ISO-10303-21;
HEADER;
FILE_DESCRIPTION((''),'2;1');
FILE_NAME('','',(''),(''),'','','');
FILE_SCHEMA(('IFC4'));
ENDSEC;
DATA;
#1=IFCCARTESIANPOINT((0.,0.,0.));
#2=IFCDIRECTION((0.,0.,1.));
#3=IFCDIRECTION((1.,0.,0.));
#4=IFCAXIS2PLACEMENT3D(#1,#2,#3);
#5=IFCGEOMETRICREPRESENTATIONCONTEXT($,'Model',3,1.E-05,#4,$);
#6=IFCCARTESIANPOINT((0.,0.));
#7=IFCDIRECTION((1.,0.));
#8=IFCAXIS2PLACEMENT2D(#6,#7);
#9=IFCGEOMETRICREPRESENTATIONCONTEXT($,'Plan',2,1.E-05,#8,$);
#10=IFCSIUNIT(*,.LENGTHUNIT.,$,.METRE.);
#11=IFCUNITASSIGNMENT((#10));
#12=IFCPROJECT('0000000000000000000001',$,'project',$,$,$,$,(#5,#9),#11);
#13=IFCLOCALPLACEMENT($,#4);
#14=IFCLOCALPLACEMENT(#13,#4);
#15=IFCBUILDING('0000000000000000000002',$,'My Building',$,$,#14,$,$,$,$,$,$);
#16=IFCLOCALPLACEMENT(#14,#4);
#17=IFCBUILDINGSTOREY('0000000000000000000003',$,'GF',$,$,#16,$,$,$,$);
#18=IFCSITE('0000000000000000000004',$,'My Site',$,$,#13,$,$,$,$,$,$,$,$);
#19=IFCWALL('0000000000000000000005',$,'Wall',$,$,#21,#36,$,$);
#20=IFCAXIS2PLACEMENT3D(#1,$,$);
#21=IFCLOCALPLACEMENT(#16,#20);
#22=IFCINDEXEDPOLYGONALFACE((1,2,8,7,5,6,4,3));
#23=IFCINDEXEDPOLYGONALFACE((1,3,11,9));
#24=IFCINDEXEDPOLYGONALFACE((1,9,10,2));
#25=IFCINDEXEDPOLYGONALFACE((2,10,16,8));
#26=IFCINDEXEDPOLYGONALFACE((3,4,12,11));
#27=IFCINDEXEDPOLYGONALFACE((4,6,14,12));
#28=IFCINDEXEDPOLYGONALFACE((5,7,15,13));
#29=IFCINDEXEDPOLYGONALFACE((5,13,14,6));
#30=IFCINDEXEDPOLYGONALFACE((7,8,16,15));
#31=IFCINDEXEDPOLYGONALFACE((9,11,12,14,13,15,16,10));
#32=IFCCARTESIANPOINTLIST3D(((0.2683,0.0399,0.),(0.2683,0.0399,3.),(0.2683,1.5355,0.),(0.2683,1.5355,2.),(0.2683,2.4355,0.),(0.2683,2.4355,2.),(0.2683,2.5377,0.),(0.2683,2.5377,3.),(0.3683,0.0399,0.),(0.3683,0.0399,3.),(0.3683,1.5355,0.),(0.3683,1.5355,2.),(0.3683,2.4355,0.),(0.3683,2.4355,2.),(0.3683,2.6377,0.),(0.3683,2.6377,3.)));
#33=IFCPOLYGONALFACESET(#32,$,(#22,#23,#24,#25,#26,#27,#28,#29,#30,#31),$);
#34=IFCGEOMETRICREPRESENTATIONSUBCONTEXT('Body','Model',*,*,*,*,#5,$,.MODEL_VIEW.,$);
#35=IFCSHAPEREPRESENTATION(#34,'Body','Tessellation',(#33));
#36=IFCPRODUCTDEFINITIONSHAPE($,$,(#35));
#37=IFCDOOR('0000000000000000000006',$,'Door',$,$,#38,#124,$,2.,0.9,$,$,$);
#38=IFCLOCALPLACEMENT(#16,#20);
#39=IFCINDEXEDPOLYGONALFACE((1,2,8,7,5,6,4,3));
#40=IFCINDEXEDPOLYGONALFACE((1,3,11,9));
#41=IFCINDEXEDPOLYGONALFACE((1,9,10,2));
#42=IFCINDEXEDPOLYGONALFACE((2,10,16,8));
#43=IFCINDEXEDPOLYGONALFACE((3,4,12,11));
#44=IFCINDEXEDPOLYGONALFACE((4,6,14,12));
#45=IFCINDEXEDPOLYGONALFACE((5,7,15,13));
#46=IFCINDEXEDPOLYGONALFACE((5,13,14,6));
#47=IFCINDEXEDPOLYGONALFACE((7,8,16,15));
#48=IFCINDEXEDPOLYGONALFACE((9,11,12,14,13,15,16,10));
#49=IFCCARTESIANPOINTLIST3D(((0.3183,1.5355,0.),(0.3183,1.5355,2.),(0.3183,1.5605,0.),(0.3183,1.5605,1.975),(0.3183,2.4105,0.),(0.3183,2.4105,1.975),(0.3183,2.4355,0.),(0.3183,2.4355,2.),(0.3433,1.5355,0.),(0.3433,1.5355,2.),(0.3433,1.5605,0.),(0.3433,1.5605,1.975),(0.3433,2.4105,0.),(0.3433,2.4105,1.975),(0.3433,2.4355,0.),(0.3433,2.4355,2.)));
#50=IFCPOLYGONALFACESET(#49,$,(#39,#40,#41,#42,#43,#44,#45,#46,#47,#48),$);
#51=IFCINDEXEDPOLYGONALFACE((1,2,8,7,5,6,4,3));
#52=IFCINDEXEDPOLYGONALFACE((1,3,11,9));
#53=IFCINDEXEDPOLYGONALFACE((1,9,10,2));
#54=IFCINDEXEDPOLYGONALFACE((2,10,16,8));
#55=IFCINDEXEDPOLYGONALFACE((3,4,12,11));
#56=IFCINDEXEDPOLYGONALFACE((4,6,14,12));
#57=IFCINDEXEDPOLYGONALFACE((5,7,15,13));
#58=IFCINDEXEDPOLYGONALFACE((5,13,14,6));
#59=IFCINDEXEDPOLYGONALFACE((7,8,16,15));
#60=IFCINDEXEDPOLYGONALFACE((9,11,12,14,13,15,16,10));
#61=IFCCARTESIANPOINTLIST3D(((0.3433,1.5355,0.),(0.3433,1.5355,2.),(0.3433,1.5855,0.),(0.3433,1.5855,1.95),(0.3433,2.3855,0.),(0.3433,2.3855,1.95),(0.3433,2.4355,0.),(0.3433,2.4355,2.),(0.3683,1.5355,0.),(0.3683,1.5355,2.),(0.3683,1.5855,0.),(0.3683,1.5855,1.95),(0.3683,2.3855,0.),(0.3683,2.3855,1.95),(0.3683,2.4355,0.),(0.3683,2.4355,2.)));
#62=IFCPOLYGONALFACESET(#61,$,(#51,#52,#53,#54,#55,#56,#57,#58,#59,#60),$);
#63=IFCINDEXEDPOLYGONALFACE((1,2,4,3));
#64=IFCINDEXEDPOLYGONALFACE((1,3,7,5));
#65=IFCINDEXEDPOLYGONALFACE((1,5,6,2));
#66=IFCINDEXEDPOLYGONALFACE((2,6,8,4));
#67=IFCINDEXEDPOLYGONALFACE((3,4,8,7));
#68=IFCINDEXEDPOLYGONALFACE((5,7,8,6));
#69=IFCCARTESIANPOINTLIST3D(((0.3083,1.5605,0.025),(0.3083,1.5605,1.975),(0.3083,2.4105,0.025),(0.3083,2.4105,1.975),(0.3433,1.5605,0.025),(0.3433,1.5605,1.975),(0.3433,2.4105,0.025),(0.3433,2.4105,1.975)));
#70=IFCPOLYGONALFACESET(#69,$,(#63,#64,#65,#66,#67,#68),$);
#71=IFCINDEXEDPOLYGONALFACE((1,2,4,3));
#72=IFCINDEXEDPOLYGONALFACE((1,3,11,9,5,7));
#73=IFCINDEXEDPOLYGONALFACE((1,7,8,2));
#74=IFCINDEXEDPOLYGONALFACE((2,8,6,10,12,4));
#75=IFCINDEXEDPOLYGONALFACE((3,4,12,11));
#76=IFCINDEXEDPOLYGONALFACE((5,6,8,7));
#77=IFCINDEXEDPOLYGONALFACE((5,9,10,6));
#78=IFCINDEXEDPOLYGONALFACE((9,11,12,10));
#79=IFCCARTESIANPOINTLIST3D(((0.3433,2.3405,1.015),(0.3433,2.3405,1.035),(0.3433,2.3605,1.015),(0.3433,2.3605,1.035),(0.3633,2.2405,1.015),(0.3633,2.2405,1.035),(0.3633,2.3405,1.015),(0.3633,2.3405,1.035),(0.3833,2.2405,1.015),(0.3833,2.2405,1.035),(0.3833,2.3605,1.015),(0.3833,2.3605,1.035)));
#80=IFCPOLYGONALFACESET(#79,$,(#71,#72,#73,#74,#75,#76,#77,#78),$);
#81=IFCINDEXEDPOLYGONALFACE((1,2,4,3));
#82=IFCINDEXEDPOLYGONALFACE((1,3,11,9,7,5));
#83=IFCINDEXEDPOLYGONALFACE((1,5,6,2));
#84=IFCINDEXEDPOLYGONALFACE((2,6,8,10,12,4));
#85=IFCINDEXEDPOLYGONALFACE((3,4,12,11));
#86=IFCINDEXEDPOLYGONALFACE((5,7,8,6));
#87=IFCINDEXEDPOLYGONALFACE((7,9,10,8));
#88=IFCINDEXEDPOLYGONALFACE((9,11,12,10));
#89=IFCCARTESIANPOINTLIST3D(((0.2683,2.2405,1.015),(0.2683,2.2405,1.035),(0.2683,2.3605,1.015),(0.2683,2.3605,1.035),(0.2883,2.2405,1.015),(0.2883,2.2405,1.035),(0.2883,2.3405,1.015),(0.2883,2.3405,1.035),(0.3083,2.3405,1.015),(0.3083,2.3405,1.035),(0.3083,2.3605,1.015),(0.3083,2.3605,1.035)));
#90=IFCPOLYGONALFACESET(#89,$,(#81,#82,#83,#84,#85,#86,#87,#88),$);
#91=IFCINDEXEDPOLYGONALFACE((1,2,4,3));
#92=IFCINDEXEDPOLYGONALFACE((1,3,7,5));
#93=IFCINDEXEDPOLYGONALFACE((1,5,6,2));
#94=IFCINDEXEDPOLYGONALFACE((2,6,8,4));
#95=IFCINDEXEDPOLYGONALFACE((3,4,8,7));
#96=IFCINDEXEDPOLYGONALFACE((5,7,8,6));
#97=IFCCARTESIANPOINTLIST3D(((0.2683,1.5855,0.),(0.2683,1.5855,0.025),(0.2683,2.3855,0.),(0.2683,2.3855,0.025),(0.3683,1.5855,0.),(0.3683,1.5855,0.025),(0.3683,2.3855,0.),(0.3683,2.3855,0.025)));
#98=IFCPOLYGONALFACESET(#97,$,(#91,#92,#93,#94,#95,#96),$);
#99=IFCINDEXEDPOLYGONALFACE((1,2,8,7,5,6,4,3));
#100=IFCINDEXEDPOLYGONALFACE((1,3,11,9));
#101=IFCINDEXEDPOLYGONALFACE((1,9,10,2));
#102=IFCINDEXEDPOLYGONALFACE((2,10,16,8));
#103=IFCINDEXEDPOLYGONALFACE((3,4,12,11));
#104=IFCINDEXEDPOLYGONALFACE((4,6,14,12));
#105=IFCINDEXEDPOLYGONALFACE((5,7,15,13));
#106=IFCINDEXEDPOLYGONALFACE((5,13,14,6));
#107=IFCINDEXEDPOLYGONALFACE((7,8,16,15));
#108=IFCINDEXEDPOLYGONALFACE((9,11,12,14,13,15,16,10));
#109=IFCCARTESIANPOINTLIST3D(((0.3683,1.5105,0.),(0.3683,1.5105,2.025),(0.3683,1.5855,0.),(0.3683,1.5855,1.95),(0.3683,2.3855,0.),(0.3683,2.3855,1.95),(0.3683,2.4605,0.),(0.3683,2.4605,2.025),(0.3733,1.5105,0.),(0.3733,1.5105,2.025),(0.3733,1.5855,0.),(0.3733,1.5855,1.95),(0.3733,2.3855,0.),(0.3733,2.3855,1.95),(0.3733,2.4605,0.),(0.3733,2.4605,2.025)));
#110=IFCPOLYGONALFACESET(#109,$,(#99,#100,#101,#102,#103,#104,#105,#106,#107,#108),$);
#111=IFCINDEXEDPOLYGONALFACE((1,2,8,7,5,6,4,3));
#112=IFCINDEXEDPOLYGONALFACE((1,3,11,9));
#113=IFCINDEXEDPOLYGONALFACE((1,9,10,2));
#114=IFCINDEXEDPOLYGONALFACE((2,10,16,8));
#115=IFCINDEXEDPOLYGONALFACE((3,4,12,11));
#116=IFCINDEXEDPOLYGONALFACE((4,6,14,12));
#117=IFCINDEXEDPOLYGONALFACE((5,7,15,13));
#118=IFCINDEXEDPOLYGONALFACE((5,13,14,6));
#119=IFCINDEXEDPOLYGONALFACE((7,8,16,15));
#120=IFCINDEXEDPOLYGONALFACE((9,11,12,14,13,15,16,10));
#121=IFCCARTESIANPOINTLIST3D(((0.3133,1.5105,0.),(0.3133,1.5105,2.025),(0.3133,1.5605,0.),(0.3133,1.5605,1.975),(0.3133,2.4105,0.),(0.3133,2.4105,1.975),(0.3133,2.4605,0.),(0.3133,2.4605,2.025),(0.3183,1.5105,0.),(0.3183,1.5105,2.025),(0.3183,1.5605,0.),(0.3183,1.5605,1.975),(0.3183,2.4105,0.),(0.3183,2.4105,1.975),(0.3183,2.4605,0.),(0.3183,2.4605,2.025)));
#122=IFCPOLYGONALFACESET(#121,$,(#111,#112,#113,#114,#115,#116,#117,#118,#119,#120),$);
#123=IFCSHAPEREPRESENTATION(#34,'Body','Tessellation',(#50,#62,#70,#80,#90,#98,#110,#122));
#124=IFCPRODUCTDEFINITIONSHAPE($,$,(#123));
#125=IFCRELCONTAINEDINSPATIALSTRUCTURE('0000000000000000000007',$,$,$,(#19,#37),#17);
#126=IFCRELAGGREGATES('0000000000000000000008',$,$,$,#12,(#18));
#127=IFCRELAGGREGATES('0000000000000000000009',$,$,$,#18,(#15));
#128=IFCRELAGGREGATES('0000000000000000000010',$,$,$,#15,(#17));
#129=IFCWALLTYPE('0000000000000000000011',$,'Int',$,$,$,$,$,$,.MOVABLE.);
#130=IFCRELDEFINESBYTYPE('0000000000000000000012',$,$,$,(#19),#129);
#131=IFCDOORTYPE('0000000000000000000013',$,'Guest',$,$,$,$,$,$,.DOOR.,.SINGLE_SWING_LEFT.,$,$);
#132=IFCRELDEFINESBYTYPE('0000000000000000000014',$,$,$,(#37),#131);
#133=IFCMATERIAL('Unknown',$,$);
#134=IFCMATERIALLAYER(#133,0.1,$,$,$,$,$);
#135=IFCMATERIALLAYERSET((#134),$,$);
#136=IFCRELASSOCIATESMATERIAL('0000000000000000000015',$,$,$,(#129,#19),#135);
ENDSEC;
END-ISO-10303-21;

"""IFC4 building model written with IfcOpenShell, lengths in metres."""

from ifc_helpers import new_model, entity, si_unit, frame, origin_with_axes, origin_2d_with_axis, place, context, subcontext, project, spatial, line, indexed_curve, outline, extrude, shape, source, transform, mapped, material, layer, layer_set, layer_usage, type_object, type_shapes, element, fill, save


model = new_model("IFC4")

# Units and contexts
model_context = context("Model", 3, precision=1e-05, world=origin_with_axes())
plan_context = context("Plan", 2, precision=1e-05, world=origin_2d_with_axis())
body_context_1 = subcontext(model_context, "Body", "Model", "MODEL_VIEW")
body_context_2 = subcontext(plan_context, "Body", "Plan", "PLAN_VIEW")
ifc_project = project(units=[si_unit("LENGTHUNIT", "METRE")], contexts=[model_context, plan_context])

# Site, building, storey
site_placement = place(None, origin_with_axes())
site = spatial("IfcSite", under=ifc_project, at=site_placement, Name="My Site")
building_placement = place(site_placement, origin_with_axes())
building = spatial("IfcBuilding", under=site, at=building_placement, Name="My Building")
storey_placement = place(building_placement, origin_with_axes())
storey = spatial("IfcBuildingStorey", under=building, at=storey_placement, Name="GF")

# Shared definitions
ifc_material = material(Name="Unknown")

# Wall, opening, door
ifc_layer_1 = layer(ifc_material, 0.1)
ifc_layer_set_1 = layer_set([ifc_layer_1])
ifc_layer_usage_1 = layer_usage(ifc_layer_set_1, "AXIS2", "POSITIVE", 0.0)
wall_type_1 = type_object("IfcWallType", Name="Int", PredefinedType="MOVABLE", material=ifc_layer_set_1)
wall_1_placement = place(storey_placement, frame((0.2683, 2.5377, 0.0), z_axis=(0.0, 0.0, 1.0), x_axis=(0.0, -1.0, 0.0)))
wall_1 = element("IfcWall", 1, at=wall_1_placement, inside=storey, type_object=wall_type_1, material=ifc_layer_usage_1, Name="Wall", context=body_context_1, shape_type="SweptSolid", body=[
    extrude(outline(indexed_curve([(0.0, 0.0), (-0.1, 0.1), (2.4978, 0.1), (2.4978, 0.0)], segments=[line(1, 2, 3, 4, 1)])), origin_with_axes(), (0.0, 0.0, 1.0), 3.0),
])
shared_shape_1 = source(origin_with_axes(), body_context_1, "Body", "SweptSolid", [
    extrude(outline(indexed_curve([(0.0, 0.0), (0.9, 0.0), (0.9, 2.0), (0.0, 2.0)], segments=[line(1, 2, 3, 4, 1)])), frame((0.0, -0.6, 0.0), z_axis=(0.0, -1.0, 0.0), x_axis=(1.0, 0.0, 0.0)), (0.0, 0.0, -1.0), 1.2),
])
opening_1_placement = place(wall_1_placement, frame((1.0022, 0.1, 0.0), z_axis=(0.0, 0.0, 1.0), x_axis=(-1.0, 0.0, 0.0)))
opening_1 = element("IfcOpeningElement", 2, at=opening_1_placement, cuts=wall_1, PredefinedType="OPENING", context=body_context_1, shape_type="MappedRepresentation", body=[
    mapped(shared_shape_1, transform((0.0, 0.0, 0.0), x_axis=(1.0, 0.0, 0.0), y_axis=(0.0, 1.0, 0.0), z_axis=(0.0, 0.0, 1.0), scale=1.0)),
])
door_type_1 = type_object("IfcDoorType", Name="Guest", OperationType="SINGLE_SWING_LEFT", PredefinedType="DOOR")
shared_shape_2 = source(origin_with_axes(), body_context_1, "Body", "SweptSolid", [
    extrude(outline(indexed_curve([(0.0, 0.0), (0.0, 2.0), (0.9, 2.0), (0.9, 0.0), (0.875, 0.0), (0.875, 1.975), (0.025, 1.975), (0.025, 0.0)], segments=[line(1, 2, 3, 4, 5, 6, 7, 8, 1)])), frame((0.0, 0.025, 0.0), z_axis=(0.0, -1.0, 0.0), x_axis=(1.0, 0.0, 0.0)), (0.0, 0.0, -1.0), 0.025),
    extrude(outline(indexed_curve([(0.0, 0.0), (0.0, 2.0), (0.9, 2.0), (0.9, 0.0), (0.85, 0.0), (0.85, 1.95), (0.05, 1.95), (0.05, 0.0)], segments=[line(1, 2, 3, 4, 5, 6, 7, 8, 1)])), frame((0.0, 0.0, 0.0), z_axis=(0.0, -1.0, 0.0), x_axis=(1.0, 0.0, 0.0)), (0.0, 0.0, -1.0), 0.025),
    extrude(outline(indexed_curve([(0.0, 0.0), (0.85, 0.0), (0.85, 0.035), (0.0, 0.035)], segments=[line(1, 2, 3, 4, 1)])), frame((0.025, 0.025, 0.025), z_axis=(0.0, 0.0, 1.0), x_axis=(1.0, 0.0, 0.0)), (0.0, 0.0, 1.0), 1.95),
    extrude(outline(indexed_curve([(0.0, 0.0), (0.0, -0.04), (-0.12, -0.04), (-0.12, -0.02), (-0.02, -0.02), (-0.02, 0.0)], segments=[line(1, 2, 3, 4, 5, 6, 1)])), frame((0.825, 0.025, 1.015), z_axis=(0.0, 0.0, 1.0), x_axis=(1.0, 0.0, 0.0)), (0.0, 0.0, 1.0), 0.02),
    extrude(outline(indexed_curve([(0.0, 0.0), (0.0, 0.04), (-0.12, 0.04), (-0.12, 0.02), (-0.02, 0.02), (-0.02, 0.0)], segments=[line(1, 2, 3, 4, 5, 6, 1)])), frame((0.825, 0.06, 1.015), z_axis=(0.0, 0.0, 1.0), x_axis=(1.0, 0.0, 0.0)), (0.0, 0.0, 1.0), 0.02),
    extrude(outline(indexed_curve([(0.0, 0.0), (0.8, 0.0), (0.8, 0.1), (0.0, 0.1)], segments=[line(1, 2, 3, 4, 1)])), frame((0.05, 0.0, 0.0), z_axis=(0.0, 0.0, 1.0), x_axis=(1.0, 0.0, 0.0)), (0.0, 0.0, 1.0), 0.025),
    extrude(outline(indexed_curve([(0.0, 0.0), (0.0, 2.025), (0.95, 2.025), (0.95, 0.0), (0.875, 0.0), (0.875, 1.95), (0.075, 1.95), (0.075, 0.0)], segments=[line(1, 2, 3, 4, 5, 6, 7, 8, 1)])), frame((-0.025, -0.005, 0.0), z_axis=(0.0, -1.0, 0.0), x_axis=(1.0, 0.0, 0.0)), (0.0, 0.0, -1.0), 0.005),
    extrude(outline(indexed_curve([(0.0, 0.0), (0.0, 2.025), (0.95, 2.025), (0.95, 0.0), (0.9, 0.0), (0.9, 1.975), (0.05, 1.975), (0.05, 0.0)], segments=[line(1, 2, 3, 4, 5, 6, 7, 8, 1)])), frame((-0.025, 0.05, 0.0), z_axis=(0.0, -1.0, 0.0), x_axis=(1.0, 0.0, 0.0)), (0.0, 0.0, -1.0), 0.005),
])
shared_shape_3 = source(origin_with_axes(), body_context_2, "Body", "Curve2D", [
    entity("IfcIndexedPolyCurve", entity("IfcCartesianPointList2D", [[0.0, 0.0], [0.0, 0.05], [0.025, 0.05], [0.025, 0.025], [0.05, 0.025], [0.05, 0.0]]), [entity("IfcLineIndex", [1, 2, 3, 4, 5, 6, 1])]),
    entity("IfcIndexedPolyCurve", entity("IfcCartesianPointList2D", [[0.9, 0.0], [0.9, 0.05], [0.875, 0.05], [0.875, 0.025], [0.85, 0.025], [0.85, 0.0]]), [entity("IfcLineIndex", [1, 2, 3, 4, 5, 6, 1])]),
    entity("IfcTrimmedCurve", entity("IfcEllipse", entity("IfcAxis2Placement2D", entity("IfcCartesianPoint", [0.06, 0.05]), entity("IfcDirection", [1.0, 0.0])), 0.815, 0.85), [entity("IfcCartesianPoint", [0.875, 0.05])], [entity("IfcCartesianPoint", [0.06, 0.9])], True, "CARTESIAN"),
    entity("IfcIndexedPolyCurve", entity("IfcCartesianPointList2D", [[0.025, 0.05], [0.06, 0.05], [0.06, 0.9], [0.025, 0.9]]), [entity("IfcLineIndex", [1, 2, 3, 4, 1])]),
])
type_shapes(door_type_1, [shared_shape_2, shared_shape_3])
door_1_placement = place(opening_1_placement, frame((0.0, 0.0, 0.0), z_axis=(0.0, 0.0, 1.0), x_axis=(1.0, 0.0, 0.0)))
door_1 = element("IfcDoor", 3, at=door_1_placement, inside=storey, type_object=door_type_1, Name="Door", OverallHeight=2.0, OverallWidth=0.9, shapes=[
    shape(body_context_1, "Body", "MappedRepresentation", [mapped(shared_shape_2, transform((0.0, 0.0, 0.0), x_axis=(1.0, 0.0, 0.0), y_axis=(0.0, 1.0, 0.0), z_axis=(0.0, 0.0, 1.0), scale=1.0))]),
    shape(body_context_2, "Body", "MappedRepresentation", [mapped(shared_shape_3, transform((0.0, 0.0, 0.0), x_axis=(1.0, 0.0, 0.0), y_axis=(0.0, 1.0, 0.0), z_axis=(0.0, 0.0, 1.0), scale=1.0))]),
])
fill(opening_1, door_1)

save(model, "model.ifc")
